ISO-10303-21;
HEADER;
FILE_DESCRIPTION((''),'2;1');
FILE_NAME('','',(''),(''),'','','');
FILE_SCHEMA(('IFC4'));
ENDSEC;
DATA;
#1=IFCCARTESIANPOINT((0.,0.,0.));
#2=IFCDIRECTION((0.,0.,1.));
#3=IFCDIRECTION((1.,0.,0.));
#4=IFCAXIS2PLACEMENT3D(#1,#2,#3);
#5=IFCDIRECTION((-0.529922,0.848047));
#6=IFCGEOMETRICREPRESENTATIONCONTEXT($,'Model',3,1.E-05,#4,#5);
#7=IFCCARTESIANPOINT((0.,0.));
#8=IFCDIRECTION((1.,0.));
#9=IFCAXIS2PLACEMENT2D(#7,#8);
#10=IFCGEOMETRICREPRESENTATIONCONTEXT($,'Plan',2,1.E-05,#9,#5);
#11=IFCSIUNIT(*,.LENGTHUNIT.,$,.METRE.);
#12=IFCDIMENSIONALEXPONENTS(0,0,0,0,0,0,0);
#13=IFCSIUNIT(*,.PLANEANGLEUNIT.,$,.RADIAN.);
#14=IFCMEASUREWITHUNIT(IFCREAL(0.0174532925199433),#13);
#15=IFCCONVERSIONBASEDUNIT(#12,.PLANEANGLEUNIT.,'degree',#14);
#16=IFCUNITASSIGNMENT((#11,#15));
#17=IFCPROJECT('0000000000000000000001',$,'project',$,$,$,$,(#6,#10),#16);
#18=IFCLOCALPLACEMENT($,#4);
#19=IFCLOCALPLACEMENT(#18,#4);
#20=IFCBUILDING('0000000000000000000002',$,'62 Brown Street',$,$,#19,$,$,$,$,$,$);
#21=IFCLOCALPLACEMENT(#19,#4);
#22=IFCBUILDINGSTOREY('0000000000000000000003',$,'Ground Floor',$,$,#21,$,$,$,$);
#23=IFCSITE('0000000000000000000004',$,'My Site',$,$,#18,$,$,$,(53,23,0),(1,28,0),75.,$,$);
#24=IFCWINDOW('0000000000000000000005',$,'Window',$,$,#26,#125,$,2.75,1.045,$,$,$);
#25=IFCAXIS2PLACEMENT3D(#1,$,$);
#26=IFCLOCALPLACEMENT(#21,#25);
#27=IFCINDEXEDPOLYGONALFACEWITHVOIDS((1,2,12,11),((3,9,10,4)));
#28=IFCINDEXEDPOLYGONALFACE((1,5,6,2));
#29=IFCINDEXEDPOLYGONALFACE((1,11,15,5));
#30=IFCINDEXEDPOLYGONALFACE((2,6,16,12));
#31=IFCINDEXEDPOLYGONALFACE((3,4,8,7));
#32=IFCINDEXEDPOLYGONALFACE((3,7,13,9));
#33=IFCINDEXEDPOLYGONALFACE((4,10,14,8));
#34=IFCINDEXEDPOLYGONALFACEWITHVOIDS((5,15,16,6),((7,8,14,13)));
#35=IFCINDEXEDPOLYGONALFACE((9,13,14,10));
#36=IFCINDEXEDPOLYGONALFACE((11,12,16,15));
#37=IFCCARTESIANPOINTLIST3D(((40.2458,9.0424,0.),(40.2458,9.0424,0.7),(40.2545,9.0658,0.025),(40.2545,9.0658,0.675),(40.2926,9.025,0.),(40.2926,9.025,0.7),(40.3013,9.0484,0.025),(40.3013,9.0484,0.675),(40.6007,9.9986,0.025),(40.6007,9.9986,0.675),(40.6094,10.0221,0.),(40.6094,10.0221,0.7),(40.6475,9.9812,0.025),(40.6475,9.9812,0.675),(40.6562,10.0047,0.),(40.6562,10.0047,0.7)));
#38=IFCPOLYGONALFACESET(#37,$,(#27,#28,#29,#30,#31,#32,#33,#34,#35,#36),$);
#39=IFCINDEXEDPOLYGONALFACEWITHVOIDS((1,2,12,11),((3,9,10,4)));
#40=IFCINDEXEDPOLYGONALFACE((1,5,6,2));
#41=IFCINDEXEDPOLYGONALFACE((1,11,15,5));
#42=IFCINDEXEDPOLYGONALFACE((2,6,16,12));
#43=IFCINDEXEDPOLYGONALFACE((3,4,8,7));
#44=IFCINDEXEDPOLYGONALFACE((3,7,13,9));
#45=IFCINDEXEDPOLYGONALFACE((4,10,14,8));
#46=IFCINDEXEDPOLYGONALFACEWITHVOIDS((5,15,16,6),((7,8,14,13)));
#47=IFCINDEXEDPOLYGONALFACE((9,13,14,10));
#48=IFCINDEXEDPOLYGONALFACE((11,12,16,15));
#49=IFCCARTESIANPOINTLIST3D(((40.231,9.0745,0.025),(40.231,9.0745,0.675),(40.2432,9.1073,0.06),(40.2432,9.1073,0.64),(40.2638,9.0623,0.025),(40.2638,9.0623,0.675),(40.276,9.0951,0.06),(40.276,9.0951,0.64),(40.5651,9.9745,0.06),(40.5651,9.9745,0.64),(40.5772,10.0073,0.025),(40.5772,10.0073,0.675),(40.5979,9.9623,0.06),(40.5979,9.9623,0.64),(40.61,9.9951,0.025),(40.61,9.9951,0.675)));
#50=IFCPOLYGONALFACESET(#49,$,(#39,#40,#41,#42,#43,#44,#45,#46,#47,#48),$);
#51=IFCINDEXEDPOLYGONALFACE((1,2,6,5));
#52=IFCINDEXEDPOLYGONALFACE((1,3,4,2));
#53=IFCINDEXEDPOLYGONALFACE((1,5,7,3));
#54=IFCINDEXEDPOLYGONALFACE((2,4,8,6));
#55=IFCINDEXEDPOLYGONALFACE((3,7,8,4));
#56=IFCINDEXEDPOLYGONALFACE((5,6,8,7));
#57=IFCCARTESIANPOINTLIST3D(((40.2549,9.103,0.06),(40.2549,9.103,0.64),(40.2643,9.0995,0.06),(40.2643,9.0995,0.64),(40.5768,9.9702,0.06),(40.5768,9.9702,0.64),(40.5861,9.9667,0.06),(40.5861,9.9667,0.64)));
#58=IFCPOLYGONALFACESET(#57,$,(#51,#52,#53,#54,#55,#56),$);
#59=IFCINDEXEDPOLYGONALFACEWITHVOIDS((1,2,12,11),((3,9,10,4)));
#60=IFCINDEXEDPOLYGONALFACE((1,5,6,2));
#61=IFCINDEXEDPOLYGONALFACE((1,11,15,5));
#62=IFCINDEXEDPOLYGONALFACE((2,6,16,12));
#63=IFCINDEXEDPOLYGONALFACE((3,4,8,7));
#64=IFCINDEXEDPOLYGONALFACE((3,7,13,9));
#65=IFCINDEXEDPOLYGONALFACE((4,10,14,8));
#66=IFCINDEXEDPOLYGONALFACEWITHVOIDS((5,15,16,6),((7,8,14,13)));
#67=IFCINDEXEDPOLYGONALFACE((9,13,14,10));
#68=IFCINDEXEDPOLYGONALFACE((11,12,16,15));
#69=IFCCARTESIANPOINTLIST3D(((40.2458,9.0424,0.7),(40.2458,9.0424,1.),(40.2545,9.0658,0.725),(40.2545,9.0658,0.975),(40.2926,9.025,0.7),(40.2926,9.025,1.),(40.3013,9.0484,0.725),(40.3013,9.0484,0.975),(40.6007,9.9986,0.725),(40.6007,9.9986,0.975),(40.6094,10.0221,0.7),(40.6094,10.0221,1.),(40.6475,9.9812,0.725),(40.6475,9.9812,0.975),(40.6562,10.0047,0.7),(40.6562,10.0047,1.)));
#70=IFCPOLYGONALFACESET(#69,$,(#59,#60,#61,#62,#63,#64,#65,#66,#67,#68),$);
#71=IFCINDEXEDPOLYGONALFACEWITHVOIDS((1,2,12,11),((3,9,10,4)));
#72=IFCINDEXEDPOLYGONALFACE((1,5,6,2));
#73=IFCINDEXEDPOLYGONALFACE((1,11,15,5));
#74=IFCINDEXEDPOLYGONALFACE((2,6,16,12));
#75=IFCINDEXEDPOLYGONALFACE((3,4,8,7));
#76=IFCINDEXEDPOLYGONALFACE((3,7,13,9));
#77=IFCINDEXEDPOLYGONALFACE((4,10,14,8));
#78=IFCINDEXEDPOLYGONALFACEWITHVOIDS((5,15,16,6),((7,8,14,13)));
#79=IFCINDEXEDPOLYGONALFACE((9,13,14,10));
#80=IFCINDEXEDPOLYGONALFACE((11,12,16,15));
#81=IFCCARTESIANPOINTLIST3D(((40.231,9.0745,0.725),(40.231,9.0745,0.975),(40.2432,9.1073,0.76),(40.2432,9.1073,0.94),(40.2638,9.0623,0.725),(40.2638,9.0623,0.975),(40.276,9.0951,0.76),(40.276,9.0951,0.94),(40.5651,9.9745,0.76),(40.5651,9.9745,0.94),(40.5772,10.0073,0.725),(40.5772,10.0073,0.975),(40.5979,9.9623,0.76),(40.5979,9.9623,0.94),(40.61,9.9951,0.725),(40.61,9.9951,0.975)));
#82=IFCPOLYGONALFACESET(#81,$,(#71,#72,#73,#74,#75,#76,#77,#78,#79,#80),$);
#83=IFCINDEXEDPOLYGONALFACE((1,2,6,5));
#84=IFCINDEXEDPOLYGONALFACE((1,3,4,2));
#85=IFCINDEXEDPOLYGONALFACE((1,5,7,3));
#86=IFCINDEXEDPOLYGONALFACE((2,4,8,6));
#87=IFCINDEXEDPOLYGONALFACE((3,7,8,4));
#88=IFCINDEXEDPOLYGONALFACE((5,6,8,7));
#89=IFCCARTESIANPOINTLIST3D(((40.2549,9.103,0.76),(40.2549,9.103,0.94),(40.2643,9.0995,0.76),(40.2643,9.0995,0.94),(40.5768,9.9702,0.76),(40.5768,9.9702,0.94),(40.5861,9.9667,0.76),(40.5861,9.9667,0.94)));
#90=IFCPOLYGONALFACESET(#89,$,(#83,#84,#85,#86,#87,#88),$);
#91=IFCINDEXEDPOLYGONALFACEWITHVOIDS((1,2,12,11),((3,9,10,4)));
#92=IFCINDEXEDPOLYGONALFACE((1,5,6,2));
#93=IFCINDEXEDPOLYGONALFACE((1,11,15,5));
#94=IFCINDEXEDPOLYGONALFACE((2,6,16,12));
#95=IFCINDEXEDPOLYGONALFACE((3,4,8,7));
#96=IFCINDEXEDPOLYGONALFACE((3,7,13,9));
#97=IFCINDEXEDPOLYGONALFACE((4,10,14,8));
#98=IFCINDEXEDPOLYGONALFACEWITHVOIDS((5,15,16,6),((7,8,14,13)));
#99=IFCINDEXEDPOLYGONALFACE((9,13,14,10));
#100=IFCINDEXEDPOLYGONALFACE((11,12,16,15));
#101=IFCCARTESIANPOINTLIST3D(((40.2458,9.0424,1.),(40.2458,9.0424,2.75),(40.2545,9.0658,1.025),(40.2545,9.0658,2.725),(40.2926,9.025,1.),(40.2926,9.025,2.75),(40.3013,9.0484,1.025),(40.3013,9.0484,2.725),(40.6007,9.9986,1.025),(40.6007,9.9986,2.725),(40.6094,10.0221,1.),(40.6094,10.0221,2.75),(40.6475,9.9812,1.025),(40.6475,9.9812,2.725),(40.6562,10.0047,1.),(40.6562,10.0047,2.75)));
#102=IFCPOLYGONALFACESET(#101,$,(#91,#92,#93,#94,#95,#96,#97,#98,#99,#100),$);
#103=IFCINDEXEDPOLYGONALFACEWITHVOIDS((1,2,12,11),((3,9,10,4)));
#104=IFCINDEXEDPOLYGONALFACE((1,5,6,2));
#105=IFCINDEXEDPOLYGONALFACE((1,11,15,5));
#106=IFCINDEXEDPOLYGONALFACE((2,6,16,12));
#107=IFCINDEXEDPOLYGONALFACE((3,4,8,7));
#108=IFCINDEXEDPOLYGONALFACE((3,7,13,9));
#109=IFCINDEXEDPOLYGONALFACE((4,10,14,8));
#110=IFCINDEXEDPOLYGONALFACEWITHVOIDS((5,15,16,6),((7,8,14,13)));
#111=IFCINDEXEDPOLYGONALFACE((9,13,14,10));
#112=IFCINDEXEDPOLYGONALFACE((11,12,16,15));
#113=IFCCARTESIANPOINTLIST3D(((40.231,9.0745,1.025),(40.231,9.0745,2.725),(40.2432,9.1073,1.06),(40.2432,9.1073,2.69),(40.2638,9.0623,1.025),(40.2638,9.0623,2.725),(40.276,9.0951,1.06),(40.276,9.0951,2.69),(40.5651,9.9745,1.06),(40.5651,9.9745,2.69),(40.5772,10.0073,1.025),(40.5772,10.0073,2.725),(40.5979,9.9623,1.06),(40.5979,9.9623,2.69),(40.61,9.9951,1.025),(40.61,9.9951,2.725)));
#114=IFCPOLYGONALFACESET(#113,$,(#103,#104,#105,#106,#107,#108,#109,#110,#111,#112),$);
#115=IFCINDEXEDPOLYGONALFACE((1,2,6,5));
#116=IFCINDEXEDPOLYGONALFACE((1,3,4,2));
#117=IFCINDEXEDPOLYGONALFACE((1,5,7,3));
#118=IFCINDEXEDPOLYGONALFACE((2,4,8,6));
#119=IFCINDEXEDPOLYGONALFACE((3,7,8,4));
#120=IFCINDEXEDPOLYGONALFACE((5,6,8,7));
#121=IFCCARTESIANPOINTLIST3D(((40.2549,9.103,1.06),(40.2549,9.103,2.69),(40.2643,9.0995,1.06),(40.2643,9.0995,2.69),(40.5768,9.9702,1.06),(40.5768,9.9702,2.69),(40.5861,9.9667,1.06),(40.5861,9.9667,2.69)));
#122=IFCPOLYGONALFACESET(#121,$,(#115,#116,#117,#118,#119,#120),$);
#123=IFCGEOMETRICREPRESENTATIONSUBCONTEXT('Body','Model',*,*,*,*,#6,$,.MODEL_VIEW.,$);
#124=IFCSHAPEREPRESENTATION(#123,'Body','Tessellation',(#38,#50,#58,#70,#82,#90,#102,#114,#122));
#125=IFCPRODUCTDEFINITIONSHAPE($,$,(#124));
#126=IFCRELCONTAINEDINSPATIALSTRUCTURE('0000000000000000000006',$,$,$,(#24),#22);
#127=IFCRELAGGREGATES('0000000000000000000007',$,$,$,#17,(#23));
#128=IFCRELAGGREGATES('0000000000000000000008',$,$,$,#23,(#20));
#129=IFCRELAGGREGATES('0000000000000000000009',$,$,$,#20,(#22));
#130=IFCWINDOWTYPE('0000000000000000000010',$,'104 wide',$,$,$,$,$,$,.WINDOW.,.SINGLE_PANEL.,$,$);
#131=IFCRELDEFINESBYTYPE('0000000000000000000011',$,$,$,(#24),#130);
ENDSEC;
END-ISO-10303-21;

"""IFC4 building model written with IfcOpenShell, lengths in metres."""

from ifc_helpers import new_model, entity, si_unit, converted_unit, direction, frame, origin_with_axes, origin_2d_with_axis, place, context, subcontext, project, spatial, line, indexed_curve, outline, extrude, shape, source, transform, mapped, type_object, type_shapes, element, save


model = new_model("IFC4")

# Units and contexts
model_context = context("Model", 3, precision=1e-05, world=origin_with_axes(), true_north=direction((-0.529922, 0.848047)))
plan_context = context("Plan", 2, precision=1e-05, world=origin_2d_with_axis(), true_north=direction((-0.529922, 0.848047)))
body_context_1 = subcontext(model_context, "Body", "Model", "MODEL_VIEW")
body_context_2 = subcontext(plan_context, "Body", "Plan", "PLAN_VIEW")
ifc_project = project(units=[si_unit("LENGTHUNIT", "METRE"), converted_unit("PLANEANGLEUNIT", "degree", entity("IfcReal", 0.0174532925199433), si_unit("PLANEANGLEUNIT", "RADIAN"), dimensions=[0, 0, 0, 0, 0, 0, 0])], contexts=[model_context, plan_context])

# Site, building, storey
site_placement = place(None, origin_with_axes())
site = spatial("IfcSite", under=ifc_project, at=site_placement, Name="My Site", RefLatitude=(53, 23, 0), RefLongitude=(1, 28, 0), RefElevation=75.0)
building_placement = place(site_placement, origin_with_axes())
building = spatial("IfcBuilding", under=site, at=building_placement, Name="62 Brown Street")
storey_placement = place(building_placement, origin_with_axes())
storey = spatial("IfcBuildingStorey", under=building, at=storey_placement, Name="Ground Floor")

# Window
window_type_1 = type_object("IfcWindowType", Name="104 wide", PartitioningType="SINGLE_PANEL", PredefinedType="WINDOW")
shared_shape_1 = source(origin_with_axes(), body_context_1, "Body", "SweptSolid", [
    extrude(outline(indexed_curve([(0.0, 0.0), (1.045, 0.0), (1.045, 0.7), (0.0, 0.7)], segments=[line(1, 2, 3, 4, 1)]), holes=[indexed_curve([(0.025, 0.025), (1.02, 0.025), (1.02, 0.675), (0.025, 0.675)], segments=[line(1, 2, 3, 4, 1)])]), frame((0.0, 0.15, 0.0), z_axis=(0.0, -1.0, 0.0), x_axis=(1.0, 0.0, 0.0)), (0.0, 0.0, -1.0), 0.05),
    extrude(outline(indexed_curve([(0.0, 0.0), (0.995, 0.0), (0.995, 0.65), (0.0, 0.65)], segments=[line(1, 2, 3, 4, 1)]), holes=[indexed_curve([(0.035, 0.035), (0.96, 0.035), (0.96, 0.615), (0.035, 0.615)], segments=[line(1, 2, 3, 4, 1)])]), frame((0.025, 0.19, 0.025), z_axis=(0.0, -1.0, 0.0), x_axis=(1.0, 0.0, 0.0)), (0.0, 0.0, -1.0), 0.035),
    extrude(outline(indexed_curve([(0.035, 0.035), (0.96, 0.035), (0.96, 0.615), (0.035, 0.615)], segments=[line(1, 2, 3, 4, 1)])), frame((0.025, 0.2025, 0.025), z_axis=(0.0, -1.0, 0.0), x_axis=(1.0, 0.0, 0.0)), (0.0, 0.0, -1.0), 0.01),
    extrude(outline(indexed_curve([(0.0, 0.0), (1.045, 0.0), (1.045, 0.3), (0.0, 0.3)], segments=[line(1, 2, 3, 4, 1)]), holes=[indexed_curve([(0.025, 0.025), (1.02, 0.025), (1.02, 0.275), (0.025, 0.275)], segments=[line(1, 2, 3, 4, 1)])]), frame((0.0, 0.15, 0.7), z_axis=(0.0, -1.0, 0.0), x_axis=(1.0, 0.0, 0.0)), (0.0, 0.0, -1.0), 0.05),
    extrude(outline(indexed_curve([(0.0, 0.0), (0.995, 0.0), (0.995, 0.25), (0.0, 0.25)], segments=[line(1, 2, 3, 4, 1)]), holes=[indexed_curve([(0.035, 0.035), (0.96, 0.035), (0.96, 0.215), (0.035, 0.215)], segments=[line(1, 2, 3, 4, 1)])]), frame((0.025, 0.19, 0.725), z_axis=(0.0, -1.0, 0.0), x_axis=(1.0, 0.0, 0.0)), (0.0, 0.0, -1.0), 0.035),
    extrude(outline(indexed_curve([(0.035, 0.035), (0.96, 0.035), (0.96, 0.215), (0.035, 0.215)], segments=[line(1, 2, 3, 4, 1)])), frame((0.025, 0.2025, 0.725), z_axis=(0.0, -1.0, 0.0), x_axis=(1.0, 0.0, 0.0)), (0.0, 0.0, -1.0), 0.01),
    extrude(outline(indexed_curve([(0.0, 0.0), (1.045, 0.0), (1.045, 1.75), (0.0, 1.75)], segments=[line(1, 2, 3, 4, 1)]), holes=[indexed_curve([(0.025, 0.025), (1.02, 0.025), (1.02, 1.725), (0.025, 1.725)], segments=[line(1, 2, 3, 4, 1)])]), frame((0.0, 0.15, 1.0), z_axis=(0.0, -1.0, 0.0), x_axis=(1.0, 0.0, 0.0)), (0.0, 0.0, -1.0), 0.05),
    extrude(outline(indexed_curve([(0.0, 0.0), (0.995, 0.0), (0.995, 1.7), (0.0, 1.7)], segments=[line(1, 2, 3, 4, 1)]), holes=[indexed_curve([(0.035, 0.035), (0.96, 0.035), (0.96, 1.665), (0.035, 1.665)], segments=[line(1, 2, 3, 4, 1)])]), frame((0.025, 0.19, 1.025), z_axis=(0.0, -1.0, 0.0), x_axis=(1.0, 0.0, 0.0)), (0.0, 0.0, -1.0), 0.035),
    extrude(outline(indexed_curve([(0.035, 0.035), (0.96, 0.035), (0.96, 1.665), (0.035, 1.665)], segments=[line(1, 2, 3, 4, 1)])), frame((0.025, 0.2025, 1.025), z_axis=(0.0, -1.0, 0.0), x_axis=(1.0, 0.0, 0.0)), (0.0, 0.0, -1.0), 0.01),
])
shared_shape_2 = source(origin_with_axes(), body_context_2, "Body", "Curve2D", [
    entity("IfcIndexedPolyCurve", entity("IfcCartesianPointList2D", [[0.025, 0.15], [1.02, 0.15]])),
    entity("IfcIndexedPolyCurve", entity("IfcCartesianPointList2D", [[0.0, 0.2], [0.025, 0.2], [0.025, 0.15], [0.0, 0.15]]), [entity("IfcLineIndex", [1, 2, 3, 4, 1])]),
    entity("IfcIndexedPolyCurve", entity("IfcCartesianPointList2D", [[1.045, 0.2], [1.02, 0.2], [1.02, 0.15], [1.045, 0.15]]), [entity("IfcLineIndex", [1, 2, 3, 4, 1])]),
    entity("IfcIndexedPolyCurve", entity("IfcCartesianPointList2D", [[0.025, 0.19], [0.06, 0.19], [0.06, 0.225], [0.025, 0.225]]), [entity("IfcLineIndex", [1, 2, 3, 4, 1])]),
    entity("IfcIndexedPolyCurve", entity("IfcCartesianPointList2D", [[1.02, 0.19], [0.985, 0.19], [0.985, 0.225], [1.02, 0.225]]), [entity("IfcLineIndex", [1, 2, 3, 4, 1])]),
    entity("IfcIndexedPolyCurve", entity("IfcCartesianPointList2D", [[0.06, 0.19], [0.985, 0.19]])),
    entity("IfcIndexedPolyCurve", entity("IfcCartesianPointList2D", [[0.06, 0.225], [0.985, 0.225]])),
    entity("IfcIndexedPolyCurve", entity("IfcCartesianPointList2D", [[0.06, 0.2075], [0.985, 0.2075]])),
])
type_shapes(window_type_1, [shared_shape_1, shared_shape_2])
placement_1 = place(storey_placement, frame((39.024, 5.1755, 0.0), z_axis=(0.0, 0.0, 1.0), x_axis=(0.347944, 0.937515, 0.0)))
placement_2 = place(placement_1, frame((4.0504, 0.0, 0.0), z_axis=(0.0, 0.0, 1.0), x_axis=(1.0, 0.0, 0.0)))
window_1_placement = place(placement_2, frame((0.0, 0.0, 0.0), z_axis=(0.0, 0.0, 1.0), x_axis=(1.0, 0.0, 0.0)))
element("IfcWindow", 1, at=window_1_placement, inside=storey, type_object=window_type_1, Name="Window", OverallHeight=2.75, OverallWidth=1.045, shapes=[
    shape(body_context_1, "Body", "MappedRepresentation", [mapped(shared_shape_1, transform((0.0, 0.0, 0.0), x_axis=(1.0, 0.0, 0.0), y_axis=(0.0, 1.0, 0.0), z_axis=(0.0, 0.0, 1.0), scale=1.0))]),
    shape(body_context_2, "Body", "MappedRepresentation", [mapped(shared_shape_2, transform((0.0, 0.0, 0.0), x_axis=(1.0, 0.0, 0.0), y_axis=(0.0, 1.0, 0.0), z_axis=(0.0, 0.0, 1.0), scale=1.0))]),
])

save(model, "model.ifc")
